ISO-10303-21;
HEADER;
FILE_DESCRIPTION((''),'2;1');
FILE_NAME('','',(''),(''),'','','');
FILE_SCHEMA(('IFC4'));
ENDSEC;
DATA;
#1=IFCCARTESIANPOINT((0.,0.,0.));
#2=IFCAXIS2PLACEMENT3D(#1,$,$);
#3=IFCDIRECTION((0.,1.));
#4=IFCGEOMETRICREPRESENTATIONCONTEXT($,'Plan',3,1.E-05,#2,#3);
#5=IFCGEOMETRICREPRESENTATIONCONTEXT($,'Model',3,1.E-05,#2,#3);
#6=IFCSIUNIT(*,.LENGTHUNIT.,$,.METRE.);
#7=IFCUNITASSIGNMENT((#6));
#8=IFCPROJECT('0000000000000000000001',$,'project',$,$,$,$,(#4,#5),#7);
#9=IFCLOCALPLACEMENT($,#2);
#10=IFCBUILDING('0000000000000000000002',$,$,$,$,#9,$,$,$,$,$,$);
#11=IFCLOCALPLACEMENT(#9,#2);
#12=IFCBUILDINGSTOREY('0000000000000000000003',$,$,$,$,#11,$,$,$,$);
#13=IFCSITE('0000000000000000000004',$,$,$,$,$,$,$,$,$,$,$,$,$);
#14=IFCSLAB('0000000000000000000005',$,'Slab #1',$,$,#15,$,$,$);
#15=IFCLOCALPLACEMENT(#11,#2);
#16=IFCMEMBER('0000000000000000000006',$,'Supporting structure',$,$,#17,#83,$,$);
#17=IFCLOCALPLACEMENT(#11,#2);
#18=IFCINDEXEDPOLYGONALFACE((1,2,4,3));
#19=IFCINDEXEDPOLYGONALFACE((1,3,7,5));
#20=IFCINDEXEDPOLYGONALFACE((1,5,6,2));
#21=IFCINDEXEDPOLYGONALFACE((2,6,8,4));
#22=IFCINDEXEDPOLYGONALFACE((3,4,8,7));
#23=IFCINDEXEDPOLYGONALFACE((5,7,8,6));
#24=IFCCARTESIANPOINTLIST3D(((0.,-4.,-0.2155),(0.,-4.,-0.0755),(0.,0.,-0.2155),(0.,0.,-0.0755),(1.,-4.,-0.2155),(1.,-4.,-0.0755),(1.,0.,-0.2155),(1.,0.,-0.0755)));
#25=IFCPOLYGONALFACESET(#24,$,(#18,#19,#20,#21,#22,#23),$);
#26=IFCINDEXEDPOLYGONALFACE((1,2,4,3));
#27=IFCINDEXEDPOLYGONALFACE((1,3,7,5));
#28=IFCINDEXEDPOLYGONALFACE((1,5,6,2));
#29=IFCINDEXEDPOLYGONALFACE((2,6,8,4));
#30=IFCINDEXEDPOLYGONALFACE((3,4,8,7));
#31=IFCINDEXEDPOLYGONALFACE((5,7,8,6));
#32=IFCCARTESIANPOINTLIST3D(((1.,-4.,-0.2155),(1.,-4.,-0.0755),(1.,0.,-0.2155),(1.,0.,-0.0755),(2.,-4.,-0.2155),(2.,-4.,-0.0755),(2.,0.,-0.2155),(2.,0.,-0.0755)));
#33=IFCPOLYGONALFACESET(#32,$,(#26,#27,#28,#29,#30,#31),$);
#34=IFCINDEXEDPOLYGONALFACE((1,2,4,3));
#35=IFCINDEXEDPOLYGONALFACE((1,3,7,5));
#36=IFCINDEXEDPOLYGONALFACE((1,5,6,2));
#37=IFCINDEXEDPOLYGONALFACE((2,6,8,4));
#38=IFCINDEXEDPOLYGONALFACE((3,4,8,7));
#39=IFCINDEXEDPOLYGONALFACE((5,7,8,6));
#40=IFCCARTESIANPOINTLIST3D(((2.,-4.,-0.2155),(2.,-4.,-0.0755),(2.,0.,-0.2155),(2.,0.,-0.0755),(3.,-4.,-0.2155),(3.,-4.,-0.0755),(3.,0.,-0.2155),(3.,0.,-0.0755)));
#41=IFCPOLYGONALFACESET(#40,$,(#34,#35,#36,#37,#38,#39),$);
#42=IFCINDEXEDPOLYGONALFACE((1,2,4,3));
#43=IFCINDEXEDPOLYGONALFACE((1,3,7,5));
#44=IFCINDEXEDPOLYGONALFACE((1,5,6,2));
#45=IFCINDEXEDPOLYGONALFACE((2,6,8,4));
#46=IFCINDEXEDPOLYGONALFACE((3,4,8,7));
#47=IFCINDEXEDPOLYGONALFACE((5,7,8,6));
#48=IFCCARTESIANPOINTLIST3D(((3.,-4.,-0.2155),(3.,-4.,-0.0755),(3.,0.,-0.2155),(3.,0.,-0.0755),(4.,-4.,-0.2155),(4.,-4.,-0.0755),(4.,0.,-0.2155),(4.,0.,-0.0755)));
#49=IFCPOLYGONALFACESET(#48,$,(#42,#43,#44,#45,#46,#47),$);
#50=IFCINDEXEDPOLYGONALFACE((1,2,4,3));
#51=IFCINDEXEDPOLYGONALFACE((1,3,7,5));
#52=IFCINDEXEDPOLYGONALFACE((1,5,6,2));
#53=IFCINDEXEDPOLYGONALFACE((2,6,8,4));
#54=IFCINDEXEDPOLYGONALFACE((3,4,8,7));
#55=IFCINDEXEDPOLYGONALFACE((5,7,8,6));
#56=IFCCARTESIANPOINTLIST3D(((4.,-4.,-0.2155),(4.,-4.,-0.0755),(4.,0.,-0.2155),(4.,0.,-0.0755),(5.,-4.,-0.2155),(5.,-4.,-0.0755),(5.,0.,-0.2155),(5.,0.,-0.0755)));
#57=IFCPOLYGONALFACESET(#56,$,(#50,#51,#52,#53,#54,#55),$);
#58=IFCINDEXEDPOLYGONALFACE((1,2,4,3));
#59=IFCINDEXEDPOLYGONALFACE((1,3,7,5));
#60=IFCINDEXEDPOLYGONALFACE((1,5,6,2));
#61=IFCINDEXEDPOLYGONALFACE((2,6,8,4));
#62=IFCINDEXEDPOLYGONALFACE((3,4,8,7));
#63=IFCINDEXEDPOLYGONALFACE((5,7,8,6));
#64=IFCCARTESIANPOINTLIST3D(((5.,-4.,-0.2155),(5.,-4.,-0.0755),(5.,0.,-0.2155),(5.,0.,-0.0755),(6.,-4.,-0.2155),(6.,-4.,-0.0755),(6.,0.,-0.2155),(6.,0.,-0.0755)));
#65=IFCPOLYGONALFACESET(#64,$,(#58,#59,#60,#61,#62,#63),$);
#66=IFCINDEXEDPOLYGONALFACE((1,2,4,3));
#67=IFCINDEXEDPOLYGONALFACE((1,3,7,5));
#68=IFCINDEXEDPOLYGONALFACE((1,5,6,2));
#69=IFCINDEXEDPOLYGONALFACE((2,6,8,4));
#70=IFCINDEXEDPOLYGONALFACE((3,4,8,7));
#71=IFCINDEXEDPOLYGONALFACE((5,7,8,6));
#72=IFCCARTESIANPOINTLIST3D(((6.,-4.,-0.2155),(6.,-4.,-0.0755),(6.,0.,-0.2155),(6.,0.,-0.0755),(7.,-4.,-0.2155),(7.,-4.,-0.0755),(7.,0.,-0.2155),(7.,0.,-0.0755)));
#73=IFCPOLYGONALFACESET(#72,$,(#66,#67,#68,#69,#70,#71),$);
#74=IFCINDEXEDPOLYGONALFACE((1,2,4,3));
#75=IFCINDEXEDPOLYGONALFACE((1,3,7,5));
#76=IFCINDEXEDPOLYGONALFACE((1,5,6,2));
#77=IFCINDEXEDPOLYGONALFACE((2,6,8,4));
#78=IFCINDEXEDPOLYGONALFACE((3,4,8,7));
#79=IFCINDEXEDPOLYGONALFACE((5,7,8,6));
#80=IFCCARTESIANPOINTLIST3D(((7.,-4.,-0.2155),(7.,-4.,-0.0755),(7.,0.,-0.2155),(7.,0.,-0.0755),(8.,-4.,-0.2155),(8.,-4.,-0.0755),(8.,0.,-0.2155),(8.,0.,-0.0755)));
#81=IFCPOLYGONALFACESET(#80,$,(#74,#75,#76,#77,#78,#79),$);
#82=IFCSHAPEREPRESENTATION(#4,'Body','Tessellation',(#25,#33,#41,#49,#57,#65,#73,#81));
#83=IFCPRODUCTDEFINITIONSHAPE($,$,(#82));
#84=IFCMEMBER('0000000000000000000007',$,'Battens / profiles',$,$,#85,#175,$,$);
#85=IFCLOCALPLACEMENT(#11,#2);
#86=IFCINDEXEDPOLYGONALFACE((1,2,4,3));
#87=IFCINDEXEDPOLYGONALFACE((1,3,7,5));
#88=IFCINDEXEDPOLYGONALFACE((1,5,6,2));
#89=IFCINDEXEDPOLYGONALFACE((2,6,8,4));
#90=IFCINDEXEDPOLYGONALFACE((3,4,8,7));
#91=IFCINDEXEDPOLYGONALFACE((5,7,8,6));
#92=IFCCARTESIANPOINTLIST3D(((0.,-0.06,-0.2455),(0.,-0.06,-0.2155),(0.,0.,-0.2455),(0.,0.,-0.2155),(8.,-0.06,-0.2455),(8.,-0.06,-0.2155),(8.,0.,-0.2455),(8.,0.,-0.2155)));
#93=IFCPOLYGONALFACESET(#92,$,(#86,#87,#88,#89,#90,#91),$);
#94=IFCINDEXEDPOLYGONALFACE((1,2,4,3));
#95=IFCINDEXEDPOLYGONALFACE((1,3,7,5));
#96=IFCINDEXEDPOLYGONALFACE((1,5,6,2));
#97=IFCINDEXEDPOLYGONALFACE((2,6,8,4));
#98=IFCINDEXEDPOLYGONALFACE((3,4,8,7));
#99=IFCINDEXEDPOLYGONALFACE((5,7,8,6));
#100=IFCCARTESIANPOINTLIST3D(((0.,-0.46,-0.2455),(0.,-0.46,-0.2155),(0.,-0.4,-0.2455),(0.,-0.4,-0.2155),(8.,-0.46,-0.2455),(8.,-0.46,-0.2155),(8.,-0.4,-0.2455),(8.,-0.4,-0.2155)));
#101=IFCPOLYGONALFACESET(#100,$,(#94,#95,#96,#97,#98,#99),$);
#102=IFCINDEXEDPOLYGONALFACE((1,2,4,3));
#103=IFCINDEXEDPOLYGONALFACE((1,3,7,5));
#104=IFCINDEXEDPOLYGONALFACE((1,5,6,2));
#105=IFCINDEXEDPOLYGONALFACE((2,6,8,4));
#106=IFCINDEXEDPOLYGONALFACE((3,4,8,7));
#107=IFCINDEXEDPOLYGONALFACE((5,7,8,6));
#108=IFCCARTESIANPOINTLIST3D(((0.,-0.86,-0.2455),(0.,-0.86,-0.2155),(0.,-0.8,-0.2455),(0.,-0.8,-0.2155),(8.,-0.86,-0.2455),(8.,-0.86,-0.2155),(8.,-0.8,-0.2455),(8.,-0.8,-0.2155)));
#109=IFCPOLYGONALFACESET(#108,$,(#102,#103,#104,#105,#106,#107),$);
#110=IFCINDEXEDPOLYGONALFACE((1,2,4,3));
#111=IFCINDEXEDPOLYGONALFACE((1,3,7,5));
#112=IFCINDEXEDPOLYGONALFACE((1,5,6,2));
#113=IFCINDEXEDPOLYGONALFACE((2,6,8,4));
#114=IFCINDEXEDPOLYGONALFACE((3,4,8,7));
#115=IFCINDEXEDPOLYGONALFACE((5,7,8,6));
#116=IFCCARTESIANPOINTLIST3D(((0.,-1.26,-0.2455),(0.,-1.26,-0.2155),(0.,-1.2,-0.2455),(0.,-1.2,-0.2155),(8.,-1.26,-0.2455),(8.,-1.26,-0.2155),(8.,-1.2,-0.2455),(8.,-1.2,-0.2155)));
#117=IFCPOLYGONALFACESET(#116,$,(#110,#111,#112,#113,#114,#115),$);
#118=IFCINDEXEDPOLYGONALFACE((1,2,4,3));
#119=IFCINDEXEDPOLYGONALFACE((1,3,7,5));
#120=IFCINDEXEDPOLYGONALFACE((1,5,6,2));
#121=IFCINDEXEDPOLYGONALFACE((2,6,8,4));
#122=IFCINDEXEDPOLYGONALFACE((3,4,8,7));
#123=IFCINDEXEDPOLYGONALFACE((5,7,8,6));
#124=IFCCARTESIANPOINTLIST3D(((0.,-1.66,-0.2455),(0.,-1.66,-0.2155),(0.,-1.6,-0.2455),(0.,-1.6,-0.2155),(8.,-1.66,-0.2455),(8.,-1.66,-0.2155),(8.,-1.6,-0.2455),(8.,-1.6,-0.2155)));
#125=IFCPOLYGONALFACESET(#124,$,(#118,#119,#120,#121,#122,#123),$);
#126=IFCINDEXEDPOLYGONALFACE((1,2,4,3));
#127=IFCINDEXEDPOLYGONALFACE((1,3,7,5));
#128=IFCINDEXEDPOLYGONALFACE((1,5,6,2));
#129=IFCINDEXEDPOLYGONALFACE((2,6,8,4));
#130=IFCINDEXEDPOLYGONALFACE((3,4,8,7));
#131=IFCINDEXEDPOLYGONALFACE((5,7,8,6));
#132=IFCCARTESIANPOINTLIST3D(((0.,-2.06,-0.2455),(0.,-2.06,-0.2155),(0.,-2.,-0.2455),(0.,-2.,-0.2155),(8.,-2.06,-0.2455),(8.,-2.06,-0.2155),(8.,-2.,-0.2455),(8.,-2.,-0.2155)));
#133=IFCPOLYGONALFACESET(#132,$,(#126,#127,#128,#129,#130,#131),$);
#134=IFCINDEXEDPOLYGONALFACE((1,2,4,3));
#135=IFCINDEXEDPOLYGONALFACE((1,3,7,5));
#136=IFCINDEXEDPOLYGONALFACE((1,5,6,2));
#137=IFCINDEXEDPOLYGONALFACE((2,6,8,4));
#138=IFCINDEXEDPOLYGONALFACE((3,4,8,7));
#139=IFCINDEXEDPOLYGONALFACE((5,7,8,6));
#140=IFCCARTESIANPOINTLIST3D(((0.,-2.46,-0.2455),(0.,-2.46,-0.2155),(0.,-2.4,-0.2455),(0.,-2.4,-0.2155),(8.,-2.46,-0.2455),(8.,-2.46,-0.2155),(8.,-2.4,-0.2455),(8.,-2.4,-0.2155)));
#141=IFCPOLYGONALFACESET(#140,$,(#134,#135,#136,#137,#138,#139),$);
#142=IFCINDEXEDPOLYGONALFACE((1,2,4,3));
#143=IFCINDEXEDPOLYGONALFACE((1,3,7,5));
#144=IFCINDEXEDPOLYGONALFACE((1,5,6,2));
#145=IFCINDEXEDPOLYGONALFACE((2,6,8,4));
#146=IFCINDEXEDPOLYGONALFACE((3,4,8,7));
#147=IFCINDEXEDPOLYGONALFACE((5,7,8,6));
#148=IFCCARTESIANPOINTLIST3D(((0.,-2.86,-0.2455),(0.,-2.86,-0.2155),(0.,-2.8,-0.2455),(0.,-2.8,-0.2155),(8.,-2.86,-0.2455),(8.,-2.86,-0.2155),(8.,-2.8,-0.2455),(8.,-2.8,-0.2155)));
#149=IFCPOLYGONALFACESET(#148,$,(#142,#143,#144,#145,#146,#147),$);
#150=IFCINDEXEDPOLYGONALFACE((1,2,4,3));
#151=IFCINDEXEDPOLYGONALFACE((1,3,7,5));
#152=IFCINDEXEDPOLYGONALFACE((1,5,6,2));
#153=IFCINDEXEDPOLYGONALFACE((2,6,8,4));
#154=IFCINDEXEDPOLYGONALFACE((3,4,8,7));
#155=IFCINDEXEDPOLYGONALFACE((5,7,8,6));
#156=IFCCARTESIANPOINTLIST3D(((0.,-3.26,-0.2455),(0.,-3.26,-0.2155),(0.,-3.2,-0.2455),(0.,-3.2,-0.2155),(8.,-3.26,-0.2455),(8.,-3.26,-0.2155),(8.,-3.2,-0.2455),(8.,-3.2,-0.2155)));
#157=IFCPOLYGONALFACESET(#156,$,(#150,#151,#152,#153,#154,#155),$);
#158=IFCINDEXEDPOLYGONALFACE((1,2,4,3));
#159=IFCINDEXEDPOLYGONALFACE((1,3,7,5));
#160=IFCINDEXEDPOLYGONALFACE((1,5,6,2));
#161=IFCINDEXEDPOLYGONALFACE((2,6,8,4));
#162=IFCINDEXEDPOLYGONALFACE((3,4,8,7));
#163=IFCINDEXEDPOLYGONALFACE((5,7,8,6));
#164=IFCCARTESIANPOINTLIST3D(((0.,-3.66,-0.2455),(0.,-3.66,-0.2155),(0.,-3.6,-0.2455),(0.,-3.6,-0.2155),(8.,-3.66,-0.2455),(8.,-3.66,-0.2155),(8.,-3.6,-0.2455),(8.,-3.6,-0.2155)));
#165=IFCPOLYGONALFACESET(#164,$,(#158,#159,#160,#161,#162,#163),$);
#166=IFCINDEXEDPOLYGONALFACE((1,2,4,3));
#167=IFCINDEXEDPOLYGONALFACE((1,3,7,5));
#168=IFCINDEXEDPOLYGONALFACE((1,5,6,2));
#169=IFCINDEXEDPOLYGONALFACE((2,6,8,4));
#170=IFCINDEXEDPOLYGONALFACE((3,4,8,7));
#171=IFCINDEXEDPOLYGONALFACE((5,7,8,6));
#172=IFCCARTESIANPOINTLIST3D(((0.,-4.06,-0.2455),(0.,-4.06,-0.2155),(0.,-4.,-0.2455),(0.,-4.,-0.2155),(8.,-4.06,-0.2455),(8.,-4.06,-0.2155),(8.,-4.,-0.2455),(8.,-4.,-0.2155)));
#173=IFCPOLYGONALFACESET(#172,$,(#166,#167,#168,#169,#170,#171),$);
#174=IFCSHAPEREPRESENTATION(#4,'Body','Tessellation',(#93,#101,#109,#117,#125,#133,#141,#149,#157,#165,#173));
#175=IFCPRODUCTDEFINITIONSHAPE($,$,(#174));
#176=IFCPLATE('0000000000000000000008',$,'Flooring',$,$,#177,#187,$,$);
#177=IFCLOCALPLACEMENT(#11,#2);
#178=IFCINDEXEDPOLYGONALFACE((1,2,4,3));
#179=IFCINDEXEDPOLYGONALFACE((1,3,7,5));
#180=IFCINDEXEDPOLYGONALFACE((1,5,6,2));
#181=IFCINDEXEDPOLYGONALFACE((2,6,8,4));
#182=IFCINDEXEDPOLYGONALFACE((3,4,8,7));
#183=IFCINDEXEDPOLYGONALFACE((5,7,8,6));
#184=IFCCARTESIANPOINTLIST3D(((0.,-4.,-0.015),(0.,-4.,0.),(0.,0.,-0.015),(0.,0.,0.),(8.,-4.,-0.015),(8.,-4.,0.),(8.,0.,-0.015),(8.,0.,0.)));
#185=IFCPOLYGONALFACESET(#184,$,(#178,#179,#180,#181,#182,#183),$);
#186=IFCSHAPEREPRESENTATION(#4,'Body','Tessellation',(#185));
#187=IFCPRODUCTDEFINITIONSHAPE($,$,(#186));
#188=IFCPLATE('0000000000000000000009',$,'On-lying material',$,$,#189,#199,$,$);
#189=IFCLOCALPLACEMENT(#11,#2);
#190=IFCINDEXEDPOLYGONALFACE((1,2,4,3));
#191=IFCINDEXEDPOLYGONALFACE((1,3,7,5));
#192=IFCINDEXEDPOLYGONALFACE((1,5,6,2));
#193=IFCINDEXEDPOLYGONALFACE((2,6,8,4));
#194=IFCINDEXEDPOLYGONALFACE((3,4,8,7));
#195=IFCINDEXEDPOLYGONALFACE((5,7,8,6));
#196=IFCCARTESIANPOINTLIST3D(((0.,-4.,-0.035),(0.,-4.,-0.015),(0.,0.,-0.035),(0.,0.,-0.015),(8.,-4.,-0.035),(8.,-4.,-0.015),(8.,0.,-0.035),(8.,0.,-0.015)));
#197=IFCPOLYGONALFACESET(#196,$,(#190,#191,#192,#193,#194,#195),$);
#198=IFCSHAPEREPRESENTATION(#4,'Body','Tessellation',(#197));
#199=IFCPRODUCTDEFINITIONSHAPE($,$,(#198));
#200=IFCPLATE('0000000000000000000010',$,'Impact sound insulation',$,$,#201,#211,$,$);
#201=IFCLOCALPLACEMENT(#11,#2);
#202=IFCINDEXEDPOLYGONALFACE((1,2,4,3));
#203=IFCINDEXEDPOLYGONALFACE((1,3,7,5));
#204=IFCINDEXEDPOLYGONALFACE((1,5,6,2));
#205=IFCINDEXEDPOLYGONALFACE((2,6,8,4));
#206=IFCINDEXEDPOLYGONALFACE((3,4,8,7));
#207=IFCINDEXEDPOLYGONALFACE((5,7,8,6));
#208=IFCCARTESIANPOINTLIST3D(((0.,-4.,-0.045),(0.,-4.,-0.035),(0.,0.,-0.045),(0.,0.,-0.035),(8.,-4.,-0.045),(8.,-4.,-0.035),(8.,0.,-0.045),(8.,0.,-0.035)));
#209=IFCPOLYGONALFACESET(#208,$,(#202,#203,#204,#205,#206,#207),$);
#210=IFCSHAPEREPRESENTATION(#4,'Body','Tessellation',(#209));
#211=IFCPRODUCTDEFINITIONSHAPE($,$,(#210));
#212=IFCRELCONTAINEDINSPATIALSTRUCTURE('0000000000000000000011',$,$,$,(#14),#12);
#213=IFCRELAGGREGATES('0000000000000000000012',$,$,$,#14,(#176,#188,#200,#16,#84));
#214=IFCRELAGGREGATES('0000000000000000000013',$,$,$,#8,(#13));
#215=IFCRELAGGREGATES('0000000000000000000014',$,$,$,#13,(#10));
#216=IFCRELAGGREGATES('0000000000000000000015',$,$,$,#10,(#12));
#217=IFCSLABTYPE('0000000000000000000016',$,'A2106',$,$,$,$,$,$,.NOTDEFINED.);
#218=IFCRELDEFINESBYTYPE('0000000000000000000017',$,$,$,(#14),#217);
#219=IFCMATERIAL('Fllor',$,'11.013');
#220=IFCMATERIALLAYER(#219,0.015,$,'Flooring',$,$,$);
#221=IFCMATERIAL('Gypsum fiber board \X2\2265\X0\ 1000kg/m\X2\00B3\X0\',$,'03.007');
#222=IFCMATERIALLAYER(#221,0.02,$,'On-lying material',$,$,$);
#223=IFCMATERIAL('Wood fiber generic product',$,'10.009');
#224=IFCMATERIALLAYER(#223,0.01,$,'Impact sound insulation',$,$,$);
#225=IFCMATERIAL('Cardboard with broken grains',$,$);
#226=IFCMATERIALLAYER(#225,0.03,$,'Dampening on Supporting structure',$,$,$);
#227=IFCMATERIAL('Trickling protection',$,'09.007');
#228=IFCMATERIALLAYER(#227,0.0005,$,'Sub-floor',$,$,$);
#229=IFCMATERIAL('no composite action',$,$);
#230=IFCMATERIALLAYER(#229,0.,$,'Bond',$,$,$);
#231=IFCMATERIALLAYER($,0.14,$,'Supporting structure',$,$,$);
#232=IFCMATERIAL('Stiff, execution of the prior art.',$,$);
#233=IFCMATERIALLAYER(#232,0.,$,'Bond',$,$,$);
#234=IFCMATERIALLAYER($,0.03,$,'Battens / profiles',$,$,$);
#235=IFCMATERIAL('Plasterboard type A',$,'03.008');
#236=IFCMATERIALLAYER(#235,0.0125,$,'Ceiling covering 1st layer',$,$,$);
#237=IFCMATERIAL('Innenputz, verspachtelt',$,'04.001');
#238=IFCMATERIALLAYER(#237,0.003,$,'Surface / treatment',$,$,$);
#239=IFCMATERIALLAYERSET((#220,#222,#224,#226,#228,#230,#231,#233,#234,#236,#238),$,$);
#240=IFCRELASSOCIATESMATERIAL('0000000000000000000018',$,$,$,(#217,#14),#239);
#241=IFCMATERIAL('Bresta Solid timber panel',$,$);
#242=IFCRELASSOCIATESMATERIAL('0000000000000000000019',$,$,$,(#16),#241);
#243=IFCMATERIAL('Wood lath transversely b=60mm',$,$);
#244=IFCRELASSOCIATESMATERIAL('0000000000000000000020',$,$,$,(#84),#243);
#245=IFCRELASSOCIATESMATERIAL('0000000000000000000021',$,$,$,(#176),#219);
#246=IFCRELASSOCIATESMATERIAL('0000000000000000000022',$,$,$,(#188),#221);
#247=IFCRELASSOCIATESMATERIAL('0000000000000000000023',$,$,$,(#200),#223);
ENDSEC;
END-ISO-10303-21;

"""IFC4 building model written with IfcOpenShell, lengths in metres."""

from ifc_helpers import new_model, si_unit, direction, frame, frame_2d, origin, origin_with_axes, place, context, project, spatial, rectangle, extrude, material, layer, layer_set, type_object, element, aggregate, save


model = new_model("IFC4")

# Units and contexts
plan_context = context("Plan", 3, precision=1e-05, world=origin(), true_north=direction((0.0, 1.0)))
model_context = context("Model", 3, precision=1e-05, world=origin(), true_north=direction((0.0, 1.0)))
ifc_project = project(units=[si_unit("LENGTHUNIT", "METRE")], contexts=[plan_context, model_context])

# Site, building, storey
site = spatial("IfcSite", under=ifc_project)
building_placement = place(None, origin())
building = spatial("IfcBuilding", under=site, at=building_placement)
storey_placement = place(building_placement, origin())
storey = spatial("IfcBuildingStorey", under=building, at=storey_placement)

# Slab, members, plates
ifc_material_1 = material(Name="Fllor", Category="11.013")
ifc_layer_1 = layer(ifc_material_1, 0.015, Name="Flooring")
ifc_material_2 = material(Name="Gypsum fiber board ≥ 1000kg/m³", Category="03.007")
ifc_layer_2 = layer(ifc_material_2, 0.02, Name="On-lying material")
ifc_material_3 = material(Name="Wood fiber generic product", Category="10.009")
ifc_layer_3 = layer(ifc_material_3, 0.01, Name="Impact sound insulation")
ifc_material_4 = material(Name="Cardboard with broken grains")
ifc_layer_4 = layer(ifc_material_4, 0.03, Name="Dampening on Supporting structure")
ifc_material_5 = material(Name="Trickling protection", Category="09.007")
ifc_layer_5 = layer(ifc_material_5, 0.0005, Name="Sub-floor")
ifc_material_6 = material(Name="no composite action")
ifc_layer_6 = layer(ifc_material_6, 0.0, Name="Bond")
ifc_layer_7 = layer(None, 0.14, Name="Supporting structure")
ifc_material_7 = material(Name="Stiff, execution of the prior art.")
ifc_layer_8 = layer(ifc_material_7, 0.0, Name="Bond")
ifc_layer_9 = layer(None, 0.03, Name="Battens / profiles")
ifc_material_8 = material(Name="Plasterboard type A", Category="03.008")
ifc_layer_10 = layer(ifc_material_8, 0.0125, Name="Ceiling covering 1st layer")
ifc_material_9 = material(Name="Innenputz, verspachtelt", Category="04.001")
ifc_layer_11 = layer(ifc_material_9, 0.003, Name="Surface / treatment")
ifc_layer_set = layer_set([ifc_layer_1, ifc_layer_2, ifc_layer_3, ifc_layer_4, ifc_layer_5, ifc_layer_6, ifc_layer_7, ifc_layer_8, ifc_layer_9, ifc_layer_10, ifc_layer_11])
slab_type = type_object("IfcSlabType", Name="A2106", PredefinedType="NOTDEFINED", material=ifc_layer_set)
slab_placement = place(None, frame((0.0, 0.0, 0.0), z_axis=(0.0, 0.0, -1.0), x_axis=(1.0, 0.0, 0.0)))
slab = element("IfcSlab", 1, at=slab_placement, inside=storey, type_object=slab_type, material=ifc_layer_set, Name="Slab #1")
ifc_material_10 = material(Name="Bresta Solid timber panel")
member_1_placement = place(slab_placement, origin())
member_1 = element("IfcMember", 2, at=member_1_placement, material=ifc_material_10, Name="Supporting structure", context=plan_context, shape_type="SweptSolid", body=[
    extrude(rectangle(XDim=1.0, YDim=0.14, at=frame_2d((0.5, 0.07), x_axis=(1.0, 0.0))), frame((0.0, 4.0, 0.0755), z_axis=(0.0, -1.0, 0.0), x_axis=(1.0, 0.0, 0.0)), (0.0, 0.0, 1.0), 4.0),
    extrude(rectangle(XDim=1.0, YDim=0.14, at=frame_2d((0.5, 0.07), x_axis=(1.0, 0.0))), frame((1.0, 4.0, 0.0755), z_axis=(0.0, -1.0, 0.0), x_axis=(1.0, 0.0, 0.0)), (0.0, 0.0, 1.0), 4.0),
    extrude(rectangle(XDim=1.0, YDim=0.14, at=frame_2d((0.5, 0.07), x_axis=(1.0, 0.0))), frame((2.0, 4.0, 0.0755), z_axis=(0.0, -1.0, 0.0), x_axis=(1.0, 0.0, 0.0)), (0.0, 0.0, 1.0), 4.0),
    extrude(rectangle(XDim=1.0, YDim=0.14, at=frame_2d((0.5, 0.07), x_axis=(1.0, 0.0))), frame((3.0, 4.0, 0.0755), z_axis=(0.0, -1.0, 0.0), x_axis=(1.0, 0.0, 0.0)), (0.0, 0.0, 1.0), 4.0),
    extrude(rectangle(XDim=1.0, YDim=0.14, at=frame_2d((0.5, 0.07), x_axis=(1.0, 0.0))), frame((4.0, 4.0, 0.0755), z_axis=(0.0, -1.0, 0.0), x_axis=(1.0, 0.0, 0.0)), (0.0, 0.0, 1.0), 4.0),
    extrude(rectangle(XDim=1.0, YDim=0.14, at=frame_2d((0.5, 0.07), x_axis=(1.0, 0.0))), frame((5.0, 4.0, 0.0755), z_axis=(0.0, -1.0, 0.0), x_axis=(1.0, 0.0, 0.0)), (0.0, 0.0, 1.0), 4.0),
    extrude(rectangle(XDim=1.0, YDim=0.14, at=frame_2d((0.5, 0.07), x_axis=(1.0, 0.0))), frame((6.0, 4.0, 0.0755), z_axis=(0.0, -1.0, 0.0), x_axis=(1.0, 0.0, 0.0)), (0.0, 0.0, 1.0), 4.0),
    extrude(rectangle(XDim=1.0, YDim=0.14, at=frame_2d((0.5, 0.07), x_axis=(1.0, 0.0))), frame((7.0, 4.0, 0.0755), z_axis=(0.0, -1.0, 0.0), x_axis=(1.0, 0.0, 0.0)), (0.0, 0.0, 1.0), 4.0),
])
ifc_material_11 = material(Name="Wood lath transversely b=60mm")
member_2_placement = place(slab_placement, origin())
member_2 = element("IfcMember", 3, at=member_2_placement, material=ifc_material_11, Name="Battens / profiles", context=plan_context, shape_type="SweptSolid", body=[
    extrude(rectangle(XDim=0.06, YDim=0.03, at=frame_2d((0.03, 0.015), x_axis=(1.0, 0.0))), frame((0.0, 0.0, 0.2155), z_axis=(1.0, 0.0, 0.0), x_axis=(0.0, 1.0, 0.0)), (0.0, 0.0, 1.0), 8.0),
    extrude(rectangle(XDim=0.06, YDim=0.03, at=frame_2d((0.03, 0.015), x_axis=(1.0, 0.0))), frame((0.0, 0.4, 0.2155), z_axis=(1.0, 0.0, 0.0), x_axis=(0.0, 1.0, 0.0)), (0.0, 0.0, 1.0), 8.0),
    extrude(rectangle(XDim=0.06, YDim=0.03, at=frame_2d((0.03, 0.015), x_axis=(1.0, 0.0))), frame((0.0, 0.8, 0.2155), z_axis=(1.0, 0.0, 0.0), x_axis=(0.0, 1.0, 0.0)), (0.0, 0.0, 1.0), 8.0),
    extrude(rectangle(XDim=0.06, YDim=0.03, at=frame_2d((0.03, 0.015), x_axis=(1.0, 0.0))), frame((0.0, 1.2, 0.2155), z_axis=(1.0, 0.0, 0.0), x_axis=(0.0, 1.0, 0.0)), (0.0, 0.0, 1.0), 8.0),
    extrude(rectangle(XDim=0.06, YDim=0.03, at=frame_2d((0.03, 0.015), x_axis=(1.0, 0.0))), frame((0.0, 1.6, 0.2155), z_axis=(1.0, 0.0, 0.0), x_axis=(0.0, 1.0, 0.0)), (0.0, 0.0, 1.0), 8.0),
    extrude(rectangle(XDim=0.06, YDim=0.03, at=frame_2d((0.03, 0.015), x_axis=(1.0, 0.0))), frame((0.0, 2.0, 0.2155), z_axis=(1.0, 0.0, 0.0), x_axis=(0.0, 1.0, 0.0)), (0.0, 0.0, 1.0), 8.0),
    extrude(rectangle(XDim=0.06, YDim=0.03, at=frame_2d((0.03, 0.015), x_axis=(1.0, 0.0))), frame((0.0, 2.4, 0.2155), z_axis=(1.0, 0.0, 0.0), x_axis=(0.0, 1.0, 0.0)), (0.0, 0.0, 1.0), 8.0),
    extrude(rectangle(XDim=0.06, YDim=0.03, at=frame_2d((0.03, 0.015), x_axis=(1.0, 0.0))), frame((0.0, 2.8, 0.2155), z_axis=(1.0, 0.0, 0.0), x_axis=(0.0, 1.0, 0.0)), (0.0, 0.0, 1.0), 8.0),
    extrude(rectangle(XDim=0.06, YDim=0.03, at=frame_2d((0.03, 0.015), x_axis=(1.0, 0.0))), frame((0.0, 3.2, 0.2155), z_axis=(1.0, 0.0, 0.0), x_axis=(0.0, 1.0, 0.0)), (0.0, 0.0, 1.0), 8.0),
    extrude(rectangle(XDim=0.06, YDim=0.03, at=frame_2d((0.03, 0.015), x_axis=(1.0, 0.0))), frame((0.0, 3.6, 0.2155), z_axis=(1.0, 0.0, 0.0), x_axis=(0.0, 1.0, 0.0)), (0.0, 0.0, 1.0), 8.0),
    extrude(rectangle(XDim=0.06, YDim=0.03, at=frame_2d((0.03, 0.015), x_axis=(1.0, 0.0))), frame((0.0, 4.0, 0.2155), z_axis=(1.0, 0.0, 0.0), x_axis=(0.0, 1.0, 0.0)), (0.0, 0.0, 1.0), 8.0),
])
plate_1_placement = place(slab_placement, origin())
plate_1 = element("IfcPlate", 4, at=plate_1_placement, material=ifc_material_1, Name="Flooring", context=plan_context, shape_type="SweptSolid", body=[
    extrude(rectangle(XDim=8.0, YDim=4.0, at=frame_2d((4.0, 2.0), x_axis=(1.0, 0.0))), origin_with_axes(), (0.0, 0.0, 1.0), 0.015),
])
plate_2_placement = place(slab_placement, origin())
plate_2 = element("IfcPlate", 5, at=plate_2_placement, material=ifc_material_2, Name="On-lying material", context=plan_context, shape_type="SweptSolid", body=[
    extrude(rectangle(XDim=8.0, YDim=4.0, at=frame_2d((4.0, 2.0), x_axis=(1.0, 0.0))), frame((0.0, 0.0, 0.015), z_axis=(0.0, 0.0, 1.0), x_axis=(1.0, 0.0, 0.0)), (0.0, 0.0, 1.0), 0.02),
])
plate_3_placement = place(slab_placement, origin())
plate_3 = element("IfcPlate", 6, at=plate_3_placement, material=ifc_material_3, Name="Impact sound insulation", context=plan_context, shape_type="SweptSolid", body=[
    extrude(rectangle(XDim=8.0, YDim=4.0, at=frame_2d((4.0, 2.0), x_axis=(1.0, 0.0))), frame((0.0, 0.0, 0.035), z_axis=(0.0, 0.0, 1.0), x_axis=(1.0, 0.0, 0.0)), (0.0, 0.0, 1.0), 0.01),
])
aggregate(slab, [plate_1, plate_2, plate_3, member_1, member_2])

save(model, "model.ifc")
